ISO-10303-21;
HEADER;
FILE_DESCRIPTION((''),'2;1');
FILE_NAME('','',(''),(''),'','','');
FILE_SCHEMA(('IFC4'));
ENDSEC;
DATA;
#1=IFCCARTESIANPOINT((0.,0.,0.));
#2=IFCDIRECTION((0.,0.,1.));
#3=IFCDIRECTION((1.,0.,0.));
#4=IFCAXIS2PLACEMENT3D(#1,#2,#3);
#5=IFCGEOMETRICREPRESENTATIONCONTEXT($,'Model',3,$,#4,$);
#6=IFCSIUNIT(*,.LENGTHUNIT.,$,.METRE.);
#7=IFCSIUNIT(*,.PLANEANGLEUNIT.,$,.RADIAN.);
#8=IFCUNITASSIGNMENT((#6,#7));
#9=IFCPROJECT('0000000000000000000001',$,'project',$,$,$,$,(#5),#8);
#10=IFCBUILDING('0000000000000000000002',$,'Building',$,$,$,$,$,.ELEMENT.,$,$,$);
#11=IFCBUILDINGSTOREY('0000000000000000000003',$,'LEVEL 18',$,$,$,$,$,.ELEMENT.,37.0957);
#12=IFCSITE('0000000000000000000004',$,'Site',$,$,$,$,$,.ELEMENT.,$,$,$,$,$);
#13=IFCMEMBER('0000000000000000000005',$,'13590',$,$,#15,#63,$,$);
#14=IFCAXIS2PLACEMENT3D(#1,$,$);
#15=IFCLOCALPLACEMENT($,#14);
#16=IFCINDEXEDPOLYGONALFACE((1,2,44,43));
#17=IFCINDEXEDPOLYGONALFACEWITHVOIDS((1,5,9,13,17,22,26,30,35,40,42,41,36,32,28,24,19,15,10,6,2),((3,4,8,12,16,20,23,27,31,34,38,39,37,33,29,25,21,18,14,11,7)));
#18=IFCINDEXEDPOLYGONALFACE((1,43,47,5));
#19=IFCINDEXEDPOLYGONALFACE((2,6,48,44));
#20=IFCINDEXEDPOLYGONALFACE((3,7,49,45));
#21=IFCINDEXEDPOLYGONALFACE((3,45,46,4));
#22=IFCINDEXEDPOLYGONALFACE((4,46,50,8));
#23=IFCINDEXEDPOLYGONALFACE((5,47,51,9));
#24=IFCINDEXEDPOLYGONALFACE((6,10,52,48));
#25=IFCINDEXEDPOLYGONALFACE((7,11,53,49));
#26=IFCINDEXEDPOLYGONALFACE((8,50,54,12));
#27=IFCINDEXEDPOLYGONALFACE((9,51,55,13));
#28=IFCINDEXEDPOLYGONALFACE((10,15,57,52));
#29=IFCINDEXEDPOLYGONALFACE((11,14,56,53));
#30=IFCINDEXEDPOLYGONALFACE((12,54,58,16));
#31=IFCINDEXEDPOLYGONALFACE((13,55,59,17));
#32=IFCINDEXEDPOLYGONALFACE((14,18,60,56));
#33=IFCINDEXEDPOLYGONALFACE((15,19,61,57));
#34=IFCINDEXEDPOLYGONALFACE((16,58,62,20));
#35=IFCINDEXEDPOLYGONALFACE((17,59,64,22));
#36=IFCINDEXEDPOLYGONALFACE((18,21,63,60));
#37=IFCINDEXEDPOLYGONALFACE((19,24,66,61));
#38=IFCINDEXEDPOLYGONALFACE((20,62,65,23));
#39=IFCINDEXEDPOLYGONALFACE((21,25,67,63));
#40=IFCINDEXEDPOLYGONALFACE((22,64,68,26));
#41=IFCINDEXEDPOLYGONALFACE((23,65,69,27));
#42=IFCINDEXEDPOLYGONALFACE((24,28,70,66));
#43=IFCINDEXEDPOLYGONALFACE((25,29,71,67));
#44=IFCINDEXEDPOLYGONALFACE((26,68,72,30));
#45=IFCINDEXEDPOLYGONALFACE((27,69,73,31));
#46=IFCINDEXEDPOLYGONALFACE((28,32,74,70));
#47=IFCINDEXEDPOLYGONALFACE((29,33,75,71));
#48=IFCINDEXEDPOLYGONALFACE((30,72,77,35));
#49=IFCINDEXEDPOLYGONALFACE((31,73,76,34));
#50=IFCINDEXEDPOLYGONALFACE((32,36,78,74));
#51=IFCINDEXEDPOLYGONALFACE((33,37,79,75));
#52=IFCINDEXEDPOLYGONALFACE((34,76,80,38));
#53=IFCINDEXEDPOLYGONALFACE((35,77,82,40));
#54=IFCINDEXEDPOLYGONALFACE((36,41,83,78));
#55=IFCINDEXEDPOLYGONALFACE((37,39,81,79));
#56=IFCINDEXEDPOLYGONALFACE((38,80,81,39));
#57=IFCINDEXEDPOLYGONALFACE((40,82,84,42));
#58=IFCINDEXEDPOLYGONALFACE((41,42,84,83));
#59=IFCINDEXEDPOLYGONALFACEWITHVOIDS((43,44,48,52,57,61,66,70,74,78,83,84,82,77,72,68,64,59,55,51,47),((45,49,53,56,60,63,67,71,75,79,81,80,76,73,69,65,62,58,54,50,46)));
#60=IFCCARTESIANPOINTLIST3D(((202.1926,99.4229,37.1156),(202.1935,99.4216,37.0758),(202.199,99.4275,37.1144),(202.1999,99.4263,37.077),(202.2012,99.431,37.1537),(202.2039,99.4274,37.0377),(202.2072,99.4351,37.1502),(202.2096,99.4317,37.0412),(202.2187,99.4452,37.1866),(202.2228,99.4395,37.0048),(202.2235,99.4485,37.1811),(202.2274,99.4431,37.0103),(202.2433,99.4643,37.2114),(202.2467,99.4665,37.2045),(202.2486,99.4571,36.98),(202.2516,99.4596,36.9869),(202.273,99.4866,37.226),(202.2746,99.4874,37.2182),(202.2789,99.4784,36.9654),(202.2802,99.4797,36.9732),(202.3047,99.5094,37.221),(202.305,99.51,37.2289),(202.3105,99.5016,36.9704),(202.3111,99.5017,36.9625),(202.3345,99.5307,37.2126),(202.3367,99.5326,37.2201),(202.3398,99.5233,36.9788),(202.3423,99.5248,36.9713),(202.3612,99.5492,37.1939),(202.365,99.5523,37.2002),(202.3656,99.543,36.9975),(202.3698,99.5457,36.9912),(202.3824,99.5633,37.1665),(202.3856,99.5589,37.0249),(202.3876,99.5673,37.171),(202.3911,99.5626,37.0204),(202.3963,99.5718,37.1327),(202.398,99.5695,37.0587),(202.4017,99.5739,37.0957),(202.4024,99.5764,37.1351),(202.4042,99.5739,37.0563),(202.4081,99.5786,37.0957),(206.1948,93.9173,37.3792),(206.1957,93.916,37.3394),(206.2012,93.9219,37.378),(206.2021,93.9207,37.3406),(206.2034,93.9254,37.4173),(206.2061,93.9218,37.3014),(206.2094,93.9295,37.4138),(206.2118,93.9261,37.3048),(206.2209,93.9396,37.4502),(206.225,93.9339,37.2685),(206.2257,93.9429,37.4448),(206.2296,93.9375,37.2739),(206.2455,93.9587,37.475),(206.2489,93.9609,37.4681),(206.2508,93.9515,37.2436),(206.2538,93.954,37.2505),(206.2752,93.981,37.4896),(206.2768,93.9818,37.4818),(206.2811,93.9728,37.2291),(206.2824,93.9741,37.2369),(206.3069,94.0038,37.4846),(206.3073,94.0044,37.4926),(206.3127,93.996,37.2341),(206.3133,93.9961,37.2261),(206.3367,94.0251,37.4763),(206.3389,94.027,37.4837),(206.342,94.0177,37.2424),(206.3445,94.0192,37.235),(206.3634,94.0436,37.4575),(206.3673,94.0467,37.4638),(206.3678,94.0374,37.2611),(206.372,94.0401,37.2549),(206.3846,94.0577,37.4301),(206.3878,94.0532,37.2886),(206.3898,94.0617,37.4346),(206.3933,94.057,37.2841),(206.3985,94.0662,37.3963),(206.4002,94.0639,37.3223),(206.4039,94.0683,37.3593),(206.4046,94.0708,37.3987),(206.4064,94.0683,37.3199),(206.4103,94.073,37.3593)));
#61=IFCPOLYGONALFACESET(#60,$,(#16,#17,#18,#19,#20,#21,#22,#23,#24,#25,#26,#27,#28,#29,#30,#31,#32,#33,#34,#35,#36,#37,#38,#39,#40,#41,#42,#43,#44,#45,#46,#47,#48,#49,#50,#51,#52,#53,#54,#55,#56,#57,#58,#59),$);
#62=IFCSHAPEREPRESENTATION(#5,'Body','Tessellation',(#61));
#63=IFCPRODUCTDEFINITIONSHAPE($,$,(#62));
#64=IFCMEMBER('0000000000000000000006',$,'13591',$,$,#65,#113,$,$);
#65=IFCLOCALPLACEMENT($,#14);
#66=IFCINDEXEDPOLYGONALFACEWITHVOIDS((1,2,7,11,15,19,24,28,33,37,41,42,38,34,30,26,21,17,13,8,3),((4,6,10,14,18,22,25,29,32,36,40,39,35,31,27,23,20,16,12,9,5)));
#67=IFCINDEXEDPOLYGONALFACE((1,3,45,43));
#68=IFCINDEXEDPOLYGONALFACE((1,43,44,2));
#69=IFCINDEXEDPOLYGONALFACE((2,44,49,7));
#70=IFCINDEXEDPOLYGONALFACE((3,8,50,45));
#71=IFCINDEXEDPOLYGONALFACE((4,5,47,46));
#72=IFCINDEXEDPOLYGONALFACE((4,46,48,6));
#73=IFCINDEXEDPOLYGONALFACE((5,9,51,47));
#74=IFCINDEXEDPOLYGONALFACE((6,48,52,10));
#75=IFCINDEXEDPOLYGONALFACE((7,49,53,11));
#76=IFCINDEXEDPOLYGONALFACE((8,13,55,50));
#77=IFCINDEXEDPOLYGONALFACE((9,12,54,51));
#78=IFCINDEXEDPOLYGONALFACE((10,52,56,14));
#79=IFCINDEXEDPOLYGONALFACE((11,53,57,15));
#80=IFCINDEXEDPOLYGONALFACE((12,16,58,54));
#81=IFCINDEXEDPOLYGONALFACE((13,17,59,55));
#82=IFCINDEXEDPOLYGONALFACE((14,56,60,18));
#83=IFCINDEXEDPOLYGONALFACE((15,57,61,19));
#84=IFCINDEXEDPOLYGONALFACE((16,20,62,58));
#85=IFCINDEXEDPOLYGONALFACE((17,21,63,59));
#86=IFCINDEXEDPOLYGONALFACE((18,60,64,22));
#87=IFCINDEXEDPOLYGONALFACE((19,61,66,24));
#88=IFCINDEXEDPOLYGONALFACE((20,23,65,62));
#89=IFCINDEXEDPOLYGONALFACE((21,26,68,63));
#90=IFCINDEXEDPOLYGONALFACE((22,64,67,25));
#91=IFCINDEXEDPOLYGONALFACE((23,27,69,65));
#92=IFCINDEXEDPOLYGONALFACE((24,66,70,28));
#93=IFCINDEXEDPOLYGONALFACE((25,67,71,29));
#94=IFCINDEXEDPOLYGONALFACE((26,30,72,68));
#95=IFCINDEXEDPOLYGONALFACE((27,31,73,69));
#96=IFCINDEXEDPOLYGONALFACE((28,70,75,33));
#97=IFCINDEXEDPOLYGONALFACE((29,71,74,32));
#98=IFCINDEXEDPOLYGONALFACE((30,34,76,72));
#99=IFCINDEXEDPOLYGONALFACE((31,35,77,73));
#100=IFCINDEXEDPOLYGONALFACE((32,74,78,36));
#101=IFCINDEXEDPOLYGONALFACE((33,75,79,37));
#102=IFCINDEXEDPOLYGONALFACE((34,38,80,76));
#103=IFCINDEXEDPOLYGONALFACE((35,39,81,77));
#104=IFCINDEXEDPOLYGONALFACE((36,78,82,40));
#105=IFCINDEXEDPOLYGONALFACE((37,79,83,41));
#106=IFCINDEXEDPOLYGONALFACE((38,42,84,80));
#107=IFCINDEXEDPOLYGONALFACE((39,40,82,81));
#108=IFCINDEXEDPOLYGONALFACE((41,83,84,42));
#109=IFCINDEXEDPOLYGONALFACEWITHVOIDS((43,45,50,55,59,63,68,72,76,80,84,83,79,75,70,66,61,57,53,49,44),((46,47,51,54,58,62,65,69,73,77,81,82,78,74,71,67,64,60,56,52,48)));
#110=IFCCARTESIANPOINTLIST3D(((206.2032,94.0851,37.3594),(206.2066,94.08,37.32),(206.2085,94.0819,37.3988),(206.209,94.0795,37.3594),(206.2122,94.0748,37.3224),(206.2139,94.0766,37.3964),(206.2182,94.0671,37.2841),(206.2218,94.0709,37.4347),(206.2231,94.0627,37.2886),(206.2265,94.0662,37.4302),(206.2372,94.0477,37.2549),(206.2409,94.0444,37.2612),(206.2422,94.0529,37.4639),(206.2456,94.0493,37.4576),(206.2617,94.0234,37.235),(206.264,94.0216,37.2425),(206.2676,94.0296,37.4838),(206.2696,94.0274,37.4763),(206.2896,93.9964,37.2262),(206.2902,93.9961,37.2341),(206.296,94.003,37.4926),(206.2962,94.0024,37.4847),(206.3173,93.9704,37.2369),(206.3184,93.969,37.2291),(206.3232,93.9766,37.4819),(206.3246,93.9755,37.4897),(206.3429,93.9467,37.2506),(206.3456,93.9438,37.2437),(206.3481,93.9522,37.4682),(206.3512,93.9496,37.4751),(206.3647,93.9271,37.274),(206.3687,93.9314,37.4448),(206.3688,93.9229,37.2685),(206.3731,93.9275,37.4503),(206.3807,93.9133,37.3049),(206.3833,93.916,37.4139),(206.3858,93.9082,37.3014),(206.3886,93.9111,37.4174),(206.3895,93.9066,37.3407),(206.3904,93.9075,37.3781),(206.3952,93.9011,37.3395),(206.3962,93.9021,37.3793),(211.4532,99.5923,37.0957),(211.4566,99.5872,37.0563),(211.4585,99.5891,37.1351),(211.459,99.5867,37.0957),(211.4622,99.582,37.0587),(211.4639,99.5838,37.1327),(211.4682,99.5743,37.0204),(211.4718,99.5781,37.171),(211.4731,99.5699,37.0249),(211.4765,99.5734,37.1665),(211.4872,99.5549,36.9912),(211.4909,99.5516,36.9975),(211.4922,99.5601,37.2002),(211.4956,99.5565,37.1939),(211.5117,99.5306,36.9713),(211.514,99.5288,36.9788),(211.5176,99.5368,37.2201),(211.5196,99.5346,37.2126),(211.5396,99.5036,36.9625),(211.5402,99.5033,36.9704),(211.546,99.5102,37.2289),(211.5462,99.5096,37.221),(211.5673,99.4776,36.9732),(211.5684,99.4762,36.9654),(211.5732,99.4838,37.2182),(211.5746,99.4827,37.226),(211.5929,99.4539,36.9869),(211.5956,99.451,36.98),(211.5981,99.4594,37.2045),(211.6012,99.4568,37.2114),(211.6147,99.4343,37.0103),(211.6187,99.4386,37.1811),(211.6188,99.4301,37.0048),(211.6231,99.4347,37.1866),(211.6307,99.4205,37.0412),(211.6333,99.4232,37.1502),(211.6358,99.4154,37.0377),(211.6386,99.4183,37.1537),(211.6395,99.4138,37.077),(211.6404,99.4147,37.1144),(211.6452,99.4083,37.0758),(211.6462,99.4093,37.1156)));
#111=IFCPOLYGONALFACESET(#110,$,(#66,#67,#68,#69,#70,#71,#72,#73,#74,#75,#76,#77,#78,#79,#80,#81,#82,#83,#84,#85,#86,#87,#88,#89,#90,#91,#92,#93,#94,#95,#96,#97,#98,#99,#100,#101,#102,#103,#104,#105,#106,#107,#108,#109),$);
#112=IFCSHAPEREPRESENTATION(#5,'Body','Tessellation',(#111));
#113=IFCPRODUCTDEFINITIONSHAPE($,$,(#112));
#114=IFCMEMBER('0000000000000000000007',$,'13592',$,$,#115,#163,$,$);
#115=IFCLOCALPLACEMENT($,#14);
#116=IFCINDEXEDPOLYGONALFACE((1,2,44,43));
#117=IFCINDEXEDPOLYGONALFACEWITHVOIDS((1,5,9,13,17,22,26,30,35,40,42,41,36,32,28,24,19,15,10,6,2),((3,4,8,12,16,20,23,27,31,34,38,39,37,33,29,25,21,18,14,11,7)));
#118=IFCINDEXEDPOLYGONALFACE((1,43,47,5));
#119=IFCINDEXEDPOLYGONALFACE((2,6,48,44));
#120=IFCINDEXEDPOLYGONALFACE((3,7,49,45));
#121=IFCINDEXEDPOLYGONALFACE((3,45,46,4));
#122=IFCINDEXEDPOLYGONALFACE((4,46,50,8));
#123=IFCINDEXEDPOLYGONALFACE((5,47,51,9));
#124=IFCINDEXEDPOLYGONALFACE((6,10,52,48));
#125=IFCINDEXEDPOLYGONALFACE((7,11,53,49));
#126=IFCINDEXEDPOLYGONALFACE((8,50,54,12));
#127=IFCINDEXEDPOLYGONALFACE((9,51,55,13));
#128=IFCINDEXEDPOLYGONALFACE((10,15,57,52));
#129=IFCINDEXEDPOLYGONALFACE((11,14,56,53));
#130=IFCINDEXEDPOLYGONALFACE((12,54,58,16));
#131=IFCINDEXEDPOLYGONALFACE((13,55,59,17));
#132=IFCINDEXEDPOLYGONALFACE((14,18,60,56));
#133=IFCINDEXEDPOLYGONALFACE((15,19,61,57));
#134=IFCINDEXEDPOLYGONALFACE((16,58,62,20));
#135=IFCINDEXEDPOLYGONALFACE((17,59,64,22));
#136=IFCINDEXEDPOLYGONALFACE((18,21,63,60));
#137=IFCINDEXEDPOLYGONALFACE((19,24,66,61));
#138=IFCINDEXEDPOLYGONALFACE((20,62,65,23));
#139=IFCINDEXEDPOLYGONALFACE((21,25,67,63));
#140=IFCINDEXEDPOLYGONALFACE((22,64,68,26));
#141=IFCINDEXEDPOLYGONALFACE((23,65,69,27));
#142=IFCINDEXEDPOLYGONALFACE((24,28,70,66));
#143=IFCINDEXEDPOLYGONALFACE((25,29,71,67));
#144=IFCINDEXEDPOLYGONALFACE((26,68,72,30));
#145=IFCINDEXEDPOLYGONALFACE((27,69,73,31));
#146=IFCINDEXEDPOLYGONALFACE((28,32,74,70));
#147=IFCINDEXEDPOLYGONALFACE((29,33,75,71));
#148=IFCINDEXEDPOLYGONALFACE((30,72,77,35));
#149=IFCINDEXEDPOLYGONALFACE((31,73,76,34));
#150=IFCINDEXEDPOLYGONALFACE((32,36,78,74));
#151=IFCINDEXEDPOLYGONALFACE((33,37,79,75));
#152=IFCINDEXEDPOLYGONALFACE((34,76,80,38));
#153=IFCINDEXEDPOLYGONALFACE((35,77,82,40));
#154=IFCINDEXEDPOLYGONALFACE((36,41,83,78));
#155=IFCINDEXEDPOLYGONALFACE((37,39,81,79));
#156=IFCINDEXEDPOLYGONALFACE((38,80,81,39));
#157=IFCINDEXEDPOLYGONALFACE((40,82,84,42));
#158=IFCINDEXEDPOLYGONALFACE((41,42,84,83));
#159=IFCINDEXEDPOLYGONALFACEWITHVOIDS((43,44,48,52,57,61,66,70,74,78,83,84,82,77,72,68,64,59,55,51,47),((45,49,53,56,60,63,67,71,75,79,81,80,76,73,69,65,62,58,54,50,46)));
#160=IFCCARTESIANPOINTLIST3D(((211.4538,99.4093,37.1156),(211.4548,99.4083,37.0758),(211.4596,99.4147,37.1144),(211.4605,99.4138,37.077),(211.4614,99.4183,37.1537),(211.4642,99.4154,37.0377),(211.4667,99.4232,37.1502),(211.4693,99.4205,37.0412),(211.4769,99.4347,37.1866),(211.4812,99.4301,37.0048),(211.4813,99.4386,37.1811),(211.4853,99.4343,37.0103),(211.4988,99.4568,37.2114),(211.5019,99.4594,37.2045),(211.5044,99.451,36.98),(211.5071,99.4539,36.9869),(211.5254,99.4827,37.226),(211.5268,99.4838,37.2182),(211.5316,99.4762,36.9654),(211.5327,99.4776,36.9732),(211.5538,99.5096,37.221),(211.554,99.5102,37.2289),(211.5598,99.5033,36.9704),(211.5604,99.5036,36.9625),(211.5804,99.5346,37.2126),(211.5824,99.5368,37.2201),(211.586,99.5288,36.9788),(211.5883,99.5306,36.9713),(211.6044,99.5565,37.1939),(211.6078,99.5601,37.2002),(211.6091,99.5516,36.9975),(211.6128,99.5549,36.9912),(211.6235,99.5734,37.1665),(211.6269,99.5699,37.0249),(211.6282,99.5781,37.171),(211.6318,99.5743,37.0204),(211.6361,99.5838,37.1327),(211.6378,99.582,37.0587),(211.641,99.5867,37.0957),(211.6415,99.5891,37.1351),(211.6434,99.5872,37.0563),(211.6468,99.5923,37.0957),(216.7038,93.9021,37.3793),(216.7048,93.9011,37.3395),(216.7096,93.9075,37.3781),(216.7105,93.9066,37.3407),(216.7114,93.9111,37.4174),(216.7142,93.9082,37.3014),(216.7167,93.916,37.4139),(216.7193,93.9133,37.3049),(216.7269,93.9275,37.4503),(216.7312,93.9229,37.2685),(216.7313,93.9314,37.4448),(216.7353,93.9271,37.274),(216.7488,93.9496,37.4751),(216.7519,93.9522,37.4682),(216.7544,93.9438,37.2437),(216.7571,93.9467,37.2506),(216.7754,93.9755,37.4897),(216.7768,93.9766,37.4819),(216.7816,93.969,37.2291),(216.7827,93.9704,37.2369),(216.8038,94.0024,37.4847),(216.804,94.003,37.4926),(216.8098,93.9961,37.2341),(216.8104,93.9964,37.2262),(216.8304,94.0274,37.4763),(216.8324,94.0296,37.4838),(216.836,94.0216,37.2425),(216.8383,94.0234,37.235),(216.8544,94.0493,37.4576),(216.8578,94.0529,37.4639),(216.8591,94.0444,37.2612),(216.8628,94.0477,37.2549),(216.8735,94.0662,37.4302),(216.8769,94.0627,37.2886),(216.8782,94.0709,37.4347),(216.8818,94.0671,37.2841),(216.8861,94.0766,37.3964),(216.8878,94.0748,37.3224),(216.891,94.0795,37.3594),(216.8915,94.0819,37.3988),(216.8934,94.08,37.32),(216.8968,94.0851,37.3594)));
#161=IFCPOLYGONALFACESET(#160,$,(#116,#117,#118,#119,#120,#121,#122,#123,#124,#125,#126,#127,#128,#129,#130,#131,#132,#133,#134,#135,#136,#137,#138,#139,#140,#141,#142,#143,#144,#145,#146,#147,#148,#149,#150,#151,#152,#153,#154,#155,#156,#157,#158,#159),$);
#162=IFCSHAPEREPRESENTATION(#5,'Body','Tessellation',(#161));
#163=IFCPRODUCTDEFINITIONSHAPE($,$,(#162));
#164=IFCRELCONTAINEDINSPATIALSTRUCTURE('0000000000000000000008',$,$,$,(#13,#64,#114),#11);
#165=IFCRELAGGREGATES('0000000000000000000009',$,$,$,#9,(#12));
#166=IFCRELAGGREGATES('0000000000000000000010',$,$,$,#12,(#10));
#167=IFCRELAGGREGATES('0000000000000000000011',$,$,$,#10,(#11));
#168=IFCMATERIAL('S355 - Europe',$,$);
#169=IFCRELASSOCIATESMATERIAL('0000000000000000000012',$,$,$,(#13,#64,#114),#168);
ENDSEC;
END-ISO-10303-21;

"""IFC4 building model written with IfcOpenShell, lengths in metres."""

from ifc_helpers import new_model, si_unit, frame, origin_with_axes, origin_2d_with_axis, place, context, project, spatial, hollow_circle, extrude, material, material_profile, profile_set, profile_usage, element, save


model = new_model("IFC4")

# Units and contexts
model_context = context("Model", 3, world=origin_with_axes())
ifc_project = project(units=[si_unit("LENGTHUNIT", "METRE"), si_unit("PLANEANGLEUNIT", "RADIAN")], contexts=[model_context])

# Site, building, storey
site = spatial("IfcSite", under=ifc_project, Name="Site", CompositionType="ELEMENT")
building = spatial("IfcBuilding", under=site, Name="Building", CompositionType="ELEMENT")
storey = spatial("IfcBuildingStorey", under=building, Name="LEVEL 18", CompositionType="ELEMENT", Elevation=37.0957)

# Shared definitions
ifc_material = material(Name="S355 - Europe")

# Members
ifc_material_profile_1 = material_profile(ifc_material, hollow_circle(Radius=0.1337, WallThickness=0.008, at=origin_2d_with_axis()))
ifc_profile_set_1 = profile_set([ifc_material_profile_1])
ifc_profile_usage_1 = profile_usage(ifc_profile_set_1, cardinal=10)
member_1_placement = place(None, frame((202.3, 99.5, 37.0957), z_axis=(0.587551, -0.808261, 0.038702), x_axis=(0.808867, 0.587992, 0.0)))
element("IfcMember", 1, at=member_1_placement, inside=storey, material=ifc_profile_usage_1, Name="13590", context=model_context, shape_type="SweptSolid", body=[
    extrude(hollow_circle(Radius=0.1337, WallThickness=0.008, at=origin_2d_with_axis()), origin_with_axes(), (0.0, 0.0, 1.0), 6.8117),
])
ifc_material_profile_2 = material_profile(ifc_material, hollow_circle(Radius=0.1337, WallThickness=0.008, at=origin_2d_with_axis()))
ifc_profile_set_2 = profile_set([ifc_material_profile_2])
ifc_profile_usage_2 = profile_usage(ifc_profile_set_2, cardinal=10)
member_2_placement = place(None, frame((206.3, 93.9928, 37.3594), z_axis=(0.689589, 0.723372, -0.034637), x_axis=(-0.723807, 0.690003, 0.0)))
element("IfcMember", 2, at=member_2_placement, inside=storey, material=ifc_profile_usage_2, Name="13591", context=model_context, shape_type="SweptSolid", body=[
    extrude(hollow_circle(Radius=0.1337, WallThickness=0.008, at=origin_2d_with_axis()), origin_with_axes(), (0.0, 0.0, 1.0), 7.6132),
])
ifc_material_profile_3 = material_profile(ifc_material, hollow_circle(Radius=0.1337, WallThickness=0.008, at=origin_2d_with_axis()))
ifc_profile_set_3 = profile_set([ifc_material_profile_3])
ifc_profile_usage_3 = profile_usage(ifc_profile_set_3, cardinal=10)
member_3_placement = place(None, frame((211.55, 99.5, 37.0957), z_axis=(0.689589, -0.723372, 0.034637), x_axis=(0.723807, 0.690003, 0.0)))
element("IfcMember", 3, at=member_3_placement, inside=storey, material=ifc_profile_usage_3, Name="13592", context=model_context, shape_type="SweptSolid", body=[
    extrude(hollow_circle(Radius=0.1337, WallThickness=0.008, at=origin_2d_with_axis()), origin_with_axes(), (0.0, 0.0, 1.0), 7.6132),
])

save(model, "model.ifc")
